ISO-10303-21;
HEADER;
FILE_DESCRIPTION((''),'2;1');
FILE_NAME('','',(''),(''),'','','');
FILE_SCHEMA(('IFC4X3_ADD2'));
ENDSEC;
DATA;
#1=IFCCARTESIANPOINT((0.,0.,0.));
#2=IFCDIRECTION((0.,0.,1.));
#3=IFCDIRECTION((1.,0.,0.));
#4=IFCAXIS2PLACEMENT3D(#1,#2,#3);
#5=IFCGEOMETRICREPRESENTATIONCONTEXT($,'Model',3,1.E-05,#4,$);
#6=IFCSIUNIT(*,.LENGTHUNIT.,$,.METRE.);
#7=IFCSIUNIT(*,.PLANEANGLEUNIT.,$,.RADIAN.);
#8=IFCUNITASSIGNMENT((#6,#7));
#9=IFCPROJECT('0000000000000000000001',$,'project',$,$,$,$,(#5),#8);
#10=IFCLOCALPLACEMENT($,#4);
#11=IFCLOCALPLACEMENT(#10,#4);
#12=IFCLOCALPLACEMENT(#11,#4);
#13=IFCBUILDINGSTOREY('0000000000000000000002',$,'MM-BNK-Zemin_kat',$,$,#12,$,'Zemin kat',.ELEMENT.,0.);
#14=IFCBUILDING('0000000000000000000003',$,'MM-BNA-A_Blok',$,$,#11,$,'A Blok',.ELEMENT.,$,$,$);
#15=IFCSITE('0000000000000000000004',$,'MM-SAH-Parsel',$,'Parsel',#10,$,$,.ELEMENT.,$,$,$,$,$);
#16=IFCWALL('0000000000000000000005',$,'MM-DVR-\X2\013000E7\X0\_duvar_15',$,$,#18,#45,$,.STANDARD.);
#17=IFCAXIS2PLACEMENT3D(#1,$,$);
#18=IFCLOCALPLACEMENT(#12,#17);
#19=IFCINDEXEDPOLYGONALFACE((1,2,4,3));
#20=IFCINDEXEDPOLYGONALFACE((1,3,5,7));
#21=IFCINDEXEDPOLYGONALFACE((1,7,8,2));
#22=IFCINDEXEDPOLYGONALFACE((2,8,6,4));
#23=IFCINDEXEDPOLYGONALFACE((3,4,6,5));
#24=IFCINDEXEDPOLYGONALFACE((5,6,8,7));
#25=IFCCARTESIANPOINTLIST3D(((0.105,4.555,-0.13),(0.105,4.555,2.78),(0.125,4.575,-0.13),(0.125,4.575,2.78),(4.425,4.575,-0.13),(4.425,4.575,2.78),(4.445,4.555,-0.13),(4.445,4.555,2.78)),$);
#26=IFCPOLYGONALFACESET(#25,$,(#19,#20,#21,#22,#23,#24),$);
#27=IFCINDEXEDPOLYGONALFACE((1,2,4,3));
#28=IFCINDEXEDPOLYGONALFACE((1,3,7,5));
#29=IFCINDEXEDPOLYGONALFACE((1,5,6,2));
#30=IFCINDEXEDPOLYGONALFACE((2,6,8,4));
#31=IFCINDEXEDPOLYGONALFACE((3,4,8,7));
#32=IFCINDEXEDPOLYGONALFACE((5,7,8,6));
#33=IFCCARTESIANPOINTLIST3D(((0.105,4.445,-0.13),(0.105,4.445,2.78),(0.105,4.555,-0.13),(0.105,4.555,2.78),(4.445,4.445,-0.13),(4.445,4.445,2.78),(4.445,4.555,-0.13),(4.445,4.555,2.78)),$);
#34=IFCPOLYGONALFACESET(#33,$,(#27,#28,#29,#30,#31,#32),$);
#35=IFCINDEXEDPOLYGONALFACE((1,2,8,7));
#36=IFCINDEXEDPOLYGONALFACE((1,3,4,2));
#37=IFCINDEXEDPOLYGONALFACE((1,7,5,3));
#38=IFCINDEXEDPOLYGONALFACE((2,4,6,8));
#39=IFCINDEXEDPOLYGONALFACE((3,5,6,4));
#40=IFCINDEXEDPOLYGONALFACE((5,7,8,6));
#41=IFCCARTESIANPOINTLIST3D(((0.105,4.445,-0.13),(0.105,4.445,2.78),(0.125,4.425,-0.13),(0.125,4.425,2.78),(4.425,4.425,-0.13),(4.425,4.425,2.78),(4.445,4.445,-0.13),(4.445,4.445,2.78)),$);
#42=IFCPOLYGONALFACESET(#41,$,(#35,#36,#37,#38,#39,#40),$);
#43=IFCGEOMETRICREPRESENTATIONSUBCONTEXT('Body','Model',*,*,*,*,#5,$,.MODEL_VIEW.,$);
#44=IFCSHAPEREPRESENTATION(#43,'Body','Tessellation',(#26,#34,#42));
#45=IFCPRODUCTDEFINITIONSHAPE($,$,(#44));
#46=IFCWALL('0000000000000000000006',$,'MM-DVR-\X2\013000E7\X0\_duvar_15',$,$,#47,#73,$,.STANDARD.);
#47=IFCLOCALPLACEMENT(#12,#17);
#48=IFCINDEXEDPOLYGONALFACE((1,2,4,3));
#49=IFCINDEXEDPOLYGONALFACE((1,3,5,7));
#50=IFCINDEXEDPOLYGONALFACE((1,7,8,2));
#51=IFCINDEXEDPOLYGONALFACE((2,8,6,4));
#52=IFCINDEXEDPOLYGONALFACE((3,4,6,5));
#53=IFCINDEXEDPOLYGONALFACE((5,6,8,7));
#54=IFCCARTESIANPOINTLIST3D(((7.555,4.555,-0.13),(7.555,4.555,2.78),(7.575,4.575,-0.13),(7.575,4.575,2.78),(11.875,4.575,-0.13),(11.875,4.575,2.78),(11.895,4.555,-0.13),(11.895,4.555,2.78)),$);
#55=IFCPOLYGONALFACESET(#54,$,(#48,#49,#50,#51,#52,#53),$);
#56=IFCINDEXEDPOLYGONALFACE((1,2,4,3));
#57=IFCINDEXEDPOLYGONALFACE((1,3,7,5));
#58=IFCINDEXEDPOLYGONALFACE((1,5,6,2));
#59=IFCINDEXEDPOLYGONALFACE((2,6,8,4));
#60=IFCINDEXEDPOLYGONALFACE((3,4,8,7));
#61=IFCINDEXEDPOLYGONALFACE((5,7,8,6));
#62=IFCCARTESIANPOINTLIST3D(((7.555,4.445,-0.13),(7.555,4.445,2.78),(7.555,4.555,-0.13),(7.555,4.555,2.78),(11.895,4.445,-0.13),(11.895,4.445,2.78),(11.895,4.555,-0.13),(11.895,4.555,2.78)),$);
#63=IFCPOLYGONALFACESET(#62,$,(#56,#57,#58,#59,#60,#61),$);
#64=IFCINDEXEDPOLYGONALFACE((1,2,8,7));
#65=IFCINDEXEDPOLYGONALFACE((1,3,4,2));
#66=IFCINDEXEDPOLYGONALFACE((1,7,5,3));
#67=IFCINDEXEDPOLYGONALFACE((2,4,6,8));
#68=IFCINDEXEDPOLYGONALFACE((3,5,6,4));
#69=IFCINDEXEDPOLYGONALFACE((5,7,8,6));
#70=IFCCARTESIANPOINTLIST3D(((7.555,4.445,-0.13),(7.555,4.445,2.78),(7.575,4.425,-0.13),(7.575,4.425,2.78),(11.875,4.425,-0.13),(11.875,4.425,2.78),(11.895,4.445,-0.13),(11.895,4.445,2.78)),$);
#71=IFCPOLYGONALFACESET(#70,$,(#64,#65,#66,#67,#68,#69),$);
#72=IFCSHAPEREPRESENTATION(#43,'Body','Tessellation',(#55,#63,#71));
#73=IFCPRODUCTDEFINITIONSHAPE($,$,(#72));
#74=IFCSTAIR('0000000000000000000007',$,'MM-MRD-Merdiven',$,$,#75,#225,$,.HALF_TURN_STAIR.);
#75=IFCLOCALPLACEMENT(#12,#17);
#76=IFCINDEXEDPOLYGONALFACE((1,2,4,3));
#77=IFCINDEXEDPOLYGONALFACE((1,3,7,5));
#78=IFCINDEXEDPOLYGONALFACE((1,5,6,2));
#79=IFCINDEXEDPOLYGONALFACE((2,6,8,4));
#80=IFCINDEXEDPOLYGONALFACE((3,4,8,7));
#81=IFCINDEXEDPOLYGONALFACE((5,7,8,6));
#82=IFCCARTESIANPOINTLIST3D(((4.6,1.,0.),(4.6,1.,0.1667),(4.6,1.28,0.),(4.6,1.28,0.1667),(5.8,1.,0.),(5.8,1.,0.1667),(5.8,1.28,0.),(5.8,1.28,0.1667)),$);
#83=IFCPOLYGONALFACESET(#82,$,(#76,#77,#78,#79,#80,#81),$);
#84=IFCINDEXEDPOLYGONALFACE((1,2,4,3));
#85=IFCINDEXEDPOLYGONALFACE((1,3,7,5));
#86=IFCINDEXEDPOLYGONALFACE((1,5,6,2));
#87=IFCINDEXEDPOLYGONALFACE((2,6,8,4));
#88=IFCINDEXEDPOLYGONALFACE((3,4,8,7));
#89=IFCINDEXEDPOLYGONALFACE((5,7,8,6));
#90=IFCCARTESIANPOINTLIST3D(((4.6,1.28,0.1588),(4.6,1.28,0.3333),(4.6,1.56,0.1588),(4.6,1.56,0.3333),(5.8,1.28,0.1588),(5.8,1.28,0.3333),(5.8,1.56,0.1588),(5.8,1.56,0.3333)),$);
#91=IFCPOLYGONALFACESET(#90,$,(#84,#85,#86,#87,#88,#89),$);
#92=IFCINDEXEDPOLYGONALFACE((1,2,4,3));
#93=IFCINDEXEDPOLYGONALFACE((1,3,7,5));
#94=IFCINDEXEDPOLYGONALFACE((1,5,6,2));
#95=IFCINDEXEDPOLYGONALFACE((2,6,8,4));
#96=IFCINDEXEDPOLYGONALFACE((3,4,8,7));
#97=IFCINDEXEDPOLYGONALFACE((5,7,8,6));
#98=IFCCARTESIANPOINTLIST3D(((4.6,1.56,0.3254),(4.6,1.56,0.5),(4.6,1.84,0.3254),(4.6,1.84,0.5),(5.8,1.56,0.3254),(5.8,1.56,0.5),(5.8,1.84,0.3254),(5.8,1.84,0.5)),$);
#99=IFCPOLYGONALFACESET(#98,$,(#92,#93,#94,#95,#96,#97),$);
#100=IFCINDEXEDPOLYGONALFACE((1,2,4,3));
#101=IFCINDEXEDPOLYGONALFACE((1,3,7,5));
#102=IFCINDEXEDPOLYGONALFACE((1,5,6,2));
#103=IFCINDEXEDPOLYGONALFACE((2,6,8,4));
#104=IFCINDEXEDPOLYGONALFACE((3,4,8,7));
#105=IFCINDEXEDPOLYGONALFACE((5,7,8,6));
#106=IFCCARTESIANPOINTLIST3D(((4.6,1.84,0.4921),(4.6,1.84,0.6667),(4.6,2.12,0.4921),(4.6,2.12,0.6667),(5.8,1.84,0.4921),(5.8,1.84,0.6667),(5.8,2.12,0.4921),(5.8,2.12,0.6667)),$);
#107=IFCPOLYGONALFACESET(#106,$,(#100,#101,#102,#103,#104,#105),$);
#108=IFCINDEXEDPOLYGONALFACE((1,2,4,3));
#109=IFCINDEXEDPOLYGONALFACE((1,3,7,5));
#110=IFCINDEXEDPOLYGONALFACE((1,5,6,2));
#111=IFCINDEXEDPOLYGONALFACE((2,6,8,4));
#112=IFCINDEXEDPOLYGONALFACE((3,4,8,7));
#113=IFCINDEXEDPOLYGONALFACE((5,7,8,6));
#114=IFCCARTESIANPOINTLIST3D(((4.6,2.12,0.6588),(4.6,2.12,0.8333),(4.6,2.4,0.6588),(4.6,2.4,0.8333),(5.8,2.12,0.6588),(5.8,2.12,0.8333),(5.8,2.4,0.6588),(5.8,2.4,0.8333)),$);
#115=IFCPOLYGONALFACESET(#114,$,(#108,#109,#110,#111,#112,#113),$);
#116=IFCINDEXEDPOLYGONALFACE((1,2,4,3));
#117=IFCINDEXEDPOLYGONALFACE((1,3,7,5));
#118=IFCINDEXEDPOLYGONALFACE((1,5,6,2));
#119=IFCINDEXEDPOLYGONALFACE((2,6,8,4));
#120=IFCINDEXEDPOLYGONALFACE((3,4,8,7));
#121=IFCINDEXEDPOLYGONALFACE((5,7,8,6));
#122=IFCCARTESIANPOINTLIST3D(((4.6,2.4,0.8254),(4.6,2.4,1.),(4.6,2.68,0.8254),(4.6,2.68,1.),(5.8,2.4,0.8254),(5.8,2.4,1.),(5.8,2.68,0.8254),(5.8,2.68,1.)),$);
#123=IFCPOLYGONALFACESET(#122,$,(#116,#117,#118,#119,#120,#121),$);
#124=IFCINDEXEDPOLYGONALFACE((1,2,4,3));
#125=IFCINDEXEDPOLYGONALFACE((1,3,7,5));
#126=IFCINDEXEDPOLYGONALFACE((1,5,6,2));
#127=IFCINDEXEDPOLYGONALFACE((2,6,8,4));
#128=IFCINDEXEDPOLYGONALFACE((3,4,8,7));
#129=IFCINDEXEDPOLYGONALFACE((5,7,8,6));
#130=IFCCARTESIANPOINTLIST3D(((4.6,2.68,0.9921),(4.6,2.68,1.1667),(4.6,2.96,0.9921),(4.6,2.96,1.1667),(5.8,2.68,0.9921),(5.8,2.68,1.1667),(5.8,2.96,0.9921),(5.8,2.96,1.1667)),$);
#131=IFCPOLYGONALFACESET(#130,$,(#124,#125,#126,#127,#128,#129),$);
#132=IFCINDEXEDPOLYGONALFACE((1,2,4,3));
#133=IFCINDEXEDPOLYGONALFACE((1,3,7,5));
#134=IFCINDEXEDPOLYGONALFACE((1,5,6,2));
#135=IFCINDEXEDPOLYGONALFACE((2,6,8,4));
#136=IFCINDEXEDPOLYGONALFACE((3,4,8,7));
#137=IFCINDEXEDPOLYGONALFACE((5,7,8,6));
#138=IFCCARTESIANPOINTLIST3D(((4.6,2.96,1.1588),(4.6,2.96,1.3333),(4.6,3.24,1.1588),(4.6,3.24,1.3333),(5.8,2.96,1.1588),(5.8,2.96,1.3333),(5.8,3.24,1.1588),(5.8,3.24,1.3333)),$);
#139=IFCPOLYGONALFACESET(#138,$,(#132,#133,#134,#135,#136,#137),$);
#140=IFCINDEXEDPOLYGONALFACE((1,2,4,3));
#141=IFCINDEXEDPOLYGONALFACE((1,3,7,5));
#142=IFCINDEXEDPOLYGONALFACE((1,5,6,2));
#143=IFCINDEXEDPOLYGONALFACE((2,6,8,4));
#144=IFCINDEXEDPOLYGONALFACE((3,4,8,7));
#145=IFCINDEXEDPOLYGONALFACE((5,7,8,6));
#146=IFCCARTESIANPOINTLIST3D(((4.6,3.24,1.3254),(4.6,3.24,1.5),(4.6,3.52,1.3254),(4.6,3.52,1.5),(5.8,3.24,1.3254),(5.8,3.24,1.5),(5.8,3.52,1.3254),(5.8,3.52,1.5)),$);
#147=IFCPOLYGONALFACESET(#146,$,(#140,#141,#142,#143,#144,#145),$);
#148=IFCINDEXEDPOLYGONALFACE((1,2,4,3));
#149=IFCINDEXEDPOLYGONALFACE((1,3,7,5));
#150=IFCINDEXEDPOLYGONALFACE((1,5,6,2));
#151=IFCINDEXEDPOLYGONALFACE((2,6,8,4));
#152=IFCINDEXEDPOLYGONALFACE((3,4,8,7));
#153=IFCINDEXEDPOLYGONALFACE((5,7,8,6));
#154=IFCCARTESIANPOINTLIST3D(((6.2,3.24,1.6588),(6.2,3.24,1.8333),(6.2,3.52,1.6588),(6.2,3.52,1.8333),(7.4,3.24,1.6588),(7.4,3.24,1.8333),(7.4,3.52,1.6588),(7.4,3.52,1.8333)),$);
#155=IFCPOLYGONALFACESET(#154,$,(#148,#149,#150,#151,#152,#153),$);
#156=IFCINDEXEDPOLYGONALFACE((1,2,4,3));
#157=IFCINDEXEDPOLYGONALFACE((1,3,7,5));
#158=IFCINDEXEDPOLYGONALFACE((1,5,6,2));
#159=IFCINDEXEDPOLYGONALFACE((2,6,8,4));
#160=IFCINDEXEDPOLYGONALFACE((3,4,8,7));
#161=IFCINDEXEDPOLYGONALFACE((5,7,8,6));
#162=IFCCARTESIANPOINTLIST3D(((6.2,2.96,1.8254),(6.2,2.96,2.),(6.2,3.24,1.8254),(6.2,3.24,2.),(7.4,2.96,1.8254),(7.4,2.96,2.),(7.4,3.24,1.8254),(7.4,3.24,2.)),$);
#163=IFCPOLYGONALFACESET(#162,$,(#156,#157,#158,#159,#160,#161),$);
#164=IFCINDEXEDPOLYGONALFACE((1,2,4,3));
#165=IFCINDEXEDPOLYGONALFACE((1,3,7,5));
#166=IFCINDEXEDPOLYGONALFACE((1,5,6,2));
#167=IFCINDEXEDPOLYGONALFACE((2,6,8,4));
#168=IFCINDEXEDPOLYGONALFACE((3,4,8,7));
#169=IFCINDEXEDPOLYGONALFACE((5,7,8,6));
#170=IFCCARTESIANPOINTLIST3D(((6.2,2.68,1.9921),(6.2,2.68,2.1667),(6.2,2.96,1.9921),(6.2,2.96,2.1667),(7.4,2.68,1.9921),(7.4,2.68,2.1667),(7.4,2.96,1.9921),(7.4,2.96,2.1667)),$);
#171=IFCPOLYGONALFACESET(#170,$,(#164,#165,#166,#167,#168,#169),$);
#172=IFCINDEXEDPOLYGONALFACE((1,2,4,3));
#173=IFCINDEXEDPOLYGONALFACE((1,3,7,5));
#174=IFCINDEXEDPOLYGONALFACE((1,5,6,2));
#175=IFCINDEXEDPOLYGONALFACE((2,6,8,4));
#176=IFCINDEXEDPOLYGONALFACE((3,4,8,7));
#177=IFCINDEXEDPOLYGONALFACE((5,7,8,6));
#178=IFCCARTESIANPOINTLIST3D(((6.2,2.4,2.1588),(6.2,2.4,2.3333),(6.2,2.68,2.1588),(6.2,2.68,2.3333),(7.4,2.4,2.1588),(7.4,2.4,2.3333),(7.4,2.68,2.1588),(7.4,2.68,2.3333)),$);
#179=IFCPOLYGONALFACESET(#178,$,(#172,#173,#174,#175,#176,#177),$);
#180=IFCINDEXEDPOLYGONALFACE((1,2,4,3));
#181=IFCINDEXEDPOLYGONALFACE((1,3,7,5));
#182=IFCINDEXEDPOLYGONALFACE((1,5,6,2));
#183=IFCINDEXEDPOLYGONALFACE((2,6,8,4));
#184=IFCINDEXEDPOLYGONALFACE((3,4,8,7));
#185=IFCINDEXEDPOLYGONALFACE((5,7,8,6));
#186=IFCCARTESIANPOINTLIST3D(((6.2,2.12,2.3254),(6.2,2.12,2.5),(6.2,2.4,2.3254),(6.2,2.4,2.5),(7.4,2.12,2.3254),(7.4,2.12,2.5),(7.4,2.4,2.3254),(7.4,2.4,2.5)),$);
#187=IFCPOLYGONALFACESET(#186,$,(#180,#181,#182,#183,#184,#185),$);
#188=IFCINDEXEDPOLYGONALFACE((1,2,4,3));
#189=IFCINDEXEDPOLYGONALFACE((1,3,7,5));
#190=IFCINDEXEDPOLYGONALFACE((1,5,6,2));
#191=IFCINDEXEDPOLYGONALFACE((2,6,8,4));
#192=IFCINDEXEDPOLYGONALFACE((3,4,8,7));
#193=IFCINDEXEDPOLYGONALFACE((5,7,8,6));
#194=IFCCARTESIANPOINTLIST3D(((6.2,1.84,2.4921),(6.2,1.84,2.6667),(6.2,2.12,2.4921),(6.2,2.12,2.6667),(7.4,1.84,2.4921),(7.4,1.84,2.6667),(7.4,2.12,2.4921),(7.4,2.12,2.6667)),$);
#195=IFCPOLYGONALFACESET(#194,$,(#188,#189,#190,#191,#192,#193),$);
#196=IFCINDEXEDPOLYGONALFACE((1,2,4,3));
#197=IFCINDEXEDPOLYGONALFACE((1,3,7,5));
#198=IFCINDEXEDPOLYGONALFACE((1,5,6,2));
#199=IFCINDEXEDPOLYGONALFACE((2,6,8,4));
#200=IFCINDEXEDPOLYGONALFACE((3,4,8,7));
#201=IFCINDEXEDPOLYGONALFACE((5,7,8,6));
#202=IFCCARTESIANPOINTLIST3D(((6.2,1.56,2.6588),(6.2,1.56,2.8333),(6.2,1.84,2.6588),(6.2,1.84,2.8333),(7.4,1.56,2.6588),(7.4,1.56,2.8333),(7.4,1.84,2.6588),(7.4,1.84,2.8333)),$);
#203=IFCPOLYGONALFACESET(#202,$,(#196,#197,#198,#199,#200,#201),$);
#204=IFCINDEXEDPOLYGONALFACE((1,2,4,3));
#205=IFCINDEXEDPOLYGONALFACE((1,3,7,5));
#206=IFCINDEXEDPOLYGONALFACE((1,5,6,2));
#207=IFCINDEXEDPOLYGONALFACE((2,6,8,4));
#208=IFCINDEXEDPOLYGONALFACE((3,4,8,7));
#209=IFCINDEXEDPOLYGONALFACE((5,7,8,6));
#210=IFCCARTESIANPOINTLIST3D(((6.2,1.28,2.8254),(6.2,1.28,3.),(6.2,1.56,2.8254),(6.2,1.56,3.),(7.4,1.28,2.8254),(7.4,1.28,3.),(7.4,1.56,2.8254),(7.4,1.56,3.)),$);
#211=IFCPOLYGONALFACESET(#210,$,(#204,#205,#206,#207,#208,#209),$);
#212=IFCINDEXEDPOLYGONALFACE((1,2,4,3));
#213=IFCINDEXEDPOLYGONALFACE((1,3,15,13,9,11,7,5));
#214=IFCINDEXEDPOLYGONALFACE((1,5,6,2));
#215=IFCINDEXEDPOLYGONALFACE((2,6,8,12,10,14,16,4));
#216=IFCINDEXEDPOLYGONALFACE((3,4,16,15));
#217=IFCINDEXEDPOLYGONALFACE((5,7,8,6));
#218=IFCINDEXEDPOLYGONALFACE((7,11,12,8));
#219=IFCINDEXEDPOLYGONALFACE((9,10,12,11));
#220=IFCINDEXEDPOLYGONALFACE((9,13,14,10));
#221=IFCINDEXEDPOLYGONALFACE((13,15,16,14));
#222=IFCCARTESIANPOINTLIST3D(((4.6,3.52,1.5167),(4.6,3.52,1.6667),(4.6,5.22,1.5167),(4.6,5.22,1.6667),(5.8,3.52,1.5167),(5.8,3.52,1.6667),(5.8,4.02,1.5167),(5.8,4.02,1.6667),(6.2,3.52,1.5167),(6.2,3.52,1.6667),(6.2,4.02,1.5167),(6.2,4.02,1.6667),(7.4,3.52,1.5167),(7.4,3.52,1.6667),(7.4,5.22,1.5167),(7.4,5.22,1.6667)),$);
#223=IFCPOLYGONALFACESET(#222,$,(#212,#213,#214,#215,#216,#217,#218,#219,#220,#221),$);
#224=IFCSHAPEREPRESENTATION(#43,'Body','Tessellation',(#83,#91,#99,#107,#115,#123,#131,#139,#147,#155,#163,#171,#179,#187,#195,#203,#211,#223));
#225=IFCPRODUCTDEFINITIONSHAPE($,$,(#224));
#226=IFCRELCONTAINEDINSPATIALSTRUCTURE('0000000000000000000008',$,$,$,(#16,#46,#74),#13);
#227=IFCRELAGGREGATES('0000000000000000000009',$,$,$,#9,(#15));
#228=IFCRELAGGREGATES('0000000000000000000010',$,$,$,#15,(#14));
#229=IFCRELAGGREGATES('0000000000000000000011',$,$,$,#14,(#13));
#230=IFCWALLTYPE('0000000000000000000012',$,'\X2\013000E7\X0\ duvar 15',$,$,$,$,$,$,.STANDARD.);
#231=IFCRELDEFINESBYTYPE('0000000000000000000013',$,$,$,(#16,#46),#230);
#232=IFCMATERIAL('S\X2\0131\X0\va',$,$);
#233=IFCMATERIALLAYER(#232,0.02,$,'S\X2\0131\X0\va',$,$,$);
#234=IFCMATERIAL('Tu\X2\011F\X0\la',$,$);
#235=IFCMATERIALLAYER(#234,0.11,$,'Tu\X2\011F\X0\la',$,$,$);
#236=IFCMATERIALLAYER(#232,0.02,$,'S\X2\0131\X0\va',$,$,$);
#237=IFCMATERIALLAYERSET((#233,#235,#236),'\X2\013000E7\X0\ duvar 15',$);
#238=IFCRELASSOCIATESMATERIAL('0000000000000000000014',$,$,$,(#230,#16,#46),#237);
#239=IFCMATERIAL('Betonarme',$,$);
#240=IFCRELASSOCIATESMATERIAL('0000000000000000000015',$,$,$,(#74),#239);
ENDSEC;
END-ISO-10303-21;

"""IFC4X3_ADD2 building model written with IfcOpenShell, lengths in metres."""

from ifc_helpers import new_model, si_unit, frame, origin, origin_with_axes, place, context, subcontext, project, spatial, polyline, outline, extrude, material, layer, layer_set, type_object, element, save


model = new_model("IFC4X3_ADD2")

# Units and contexts
model_context = context("Model", 3, precision=1e-05, world=origin_with_axes())
body_context = subcontext(model_context, "Body", "Model", "MODEL_VIEW")
ifc_project = project(units=[si_unit("LENGTHUNIT", "METRE"), si_unit("PLANEANGLEUNIT", "RADIAN")], contexts=[model_context])

# Site, building, storey
site_placement = place(None, origin_with_axes())
site = spatial("IfcSite", under=ifc_project, at=site_placement, Name="MM-SAH-Parsel", ObjectType="Parsel", CompositionType="ELEMENT")
building_placement = place(site_placement, origin_with_axes())
building = spatial("IfcBuilding", under=site, at=building_placement, Name="MM-BNA-A_Blok", LongName="A Blok", CompositionType="ELEMENT")
storey_placement = place(building_placement, origin_with_axes())
storey = spatial("IfcBuildingStorey", under=building, at=storey_placement, Name="MM-BNK-Zemin_kat", LongName="Zemin kat", CompositionType="ELEMENT", Elevation=0.0)

# Shared definitions
ifc_material_1 = material(Name="Betonarme")

# Shared definitions
ifc_material_2 = material(Name="Tuğla")

# Shared definitions
ifc_material_3 = material(Name="Sıva")
ifc_layer_1 = layer(ifc_material_3, 0.02, Name="Sıva")
ifc_layer_2 = layer(ifc_material_2, 0.11, Name="Tuğla")
ifc_layer_3 = layer(ifc_material_3, 0.02, Name="Sıva")
ifc_layer_set_1 = layer_set([ifc_layer_1, ifc_layer_2, ifc_layer_3], Name="İç duvar 15")
wall_type_1 = type_object("IfcWallType", Name="İç duvar 15", PredefinedType="STANDARD", material=ifc_layer_set_1)

# Walls
wall_1_placement = place(storey_placement, origin_with_axes())
element("IfcWall", 1, at=wall_1_placement, inside=storey, type_object=wall_type_1, material=ifc_layer_set_1, Name="MM-DVR-İç_duvar_15", PredefinedType="STANDARD", context=body_context, shape_type="SweptSolid", body=[
    extrude(outline(polyline([(0.125, 4.575), (4.425, 4.575), (4.445, 4.555), (0.105, 4.555), (0.125, 4.575)])), frame((0.0, 0.0, -0.13)), (0.0, 0.0, 1.0), 2.91),
    extrude(outline(polyline([(0.105, 4.555), (4.445, 4.555), (4.445, 4.445), (0.105, 4.445), (0.105, 4.555)])), frame((0.0, 0.0, -0.13)), (0.0, 0.0, 1.0), 2.91),
    extrude(outline(polyline([(0.105, 4.445), (4.445, 4.445), (4.425, 4.425), (0.125, 4.425), (0.105, 4.445)])), frame((0.0, 0.0, -0.13)), (0.0, 0.0, 1.0), 2.91),
])
wall_2_placement = place(storey_placement, origin_with_axes())
element("IfcWall", 2, at=wall_2_placement, inside=storey, type_object=wall_type_1, material=ifc_layer_set_1, Name="MM-DVR-İç_duvar_15", PredefinedType="STANDARD", context=body_context, shape_type="SweptSolid", body=[
    extrude(outline(polyline([(7.575, 4.575), (11.875, 4.575), (11.895, 4.555), (7.555, 4.555), (7.575, 4.575)])), frame((0.0, 0.0, -0.13)), (0.0, 0.0, 1.0), 2.91),
    extrude(outline(polyline([(7.555, 4.555), (11.895, 4.555), (11.895, 4.445), (7.555, 4.445), (7.555, 4.555)])), frame((0.0, 0.0, -0.13)), (0.0, 0.0, 1.0), 2.91),
    extrude(outline(polyline([(7.555, 4.445), (11.895, 4.445), (11.875, 4.425), (7.575, 4.425), (7.555, 4.445)])), frame((0.0, 0.0, -0.13)), (0.0, 0.0, 1.0), 2.91),
])

# Stair
stair_placement = place(storey_placement, origin_with_axes())
element("IfcStair", 3, at=stair_placement, inside=storey, material=ifc_material_1, Name="MM-MRD-Merdiven", PredefinedType="HALF_TURN_STAIR", context=body_context, shape_type="SweptSolid", body=[
    extrude(outline(polyline([(5.8, 1.0), (5.8, 1.28), (4.6, 1.28), (4.6, 1.0), (5.8, 1.0)])), origin(), (0.0, 0.0, 1.0), 0.1667),
    extrude(outline(polyline([(5.8, 1.28), (5.8, 1.56), (4.6, 1.56), (4.6, 1.28), (5.8, 1.28)])), frame((0.0, 0.0, 0.1588)), (0.0, 0.0, 1.0), 0.1746),
    extrude(outline(polyline([(5.8, 1.56), (5.8, 1.84), (4.6, 1.84), (4.6, 1.56), (5.8, 1.56)])), frame((0.0, 0.0, 0.3254)), (0.0, 0.0, 1.0), 0.1746),
    extrude(outline(polyline([(5.8, 1.84), (5.8, 2.12), (4.6, 2.12), (4.6, 1.84), (5.8, 1.84)])), frame((0.0, 0.0, 0.4921)), (0.0, 0.0, 1.0), 0.1746),
    extrude(outline(polyline([(5.8, 2.12), (5.8, 2.4), (4.6, 2.4), (4.6, 2.12), (5.8, 2.12)])), frame((0.0, 0.0, 0.6588)), (0.0, 0.0, 1.0), 0.1746),
    extrude(outline(polyline([(5.8, 2.4), (5.8, 2.68), (4.6, 2.68), (4.6, 2.4), (5.8, 2.4)])), frame((0.0, 0.0, 0.8254)), (0.0, 0.0, 1.0), 0.1746),
    extrude(outline(polyline([(5.8, 2.68), (5.8, 2.96), (4.6, 2.96), (4.6, 2.68), (5.8, 2.68)])), frame((0.0, 0.0, 0.9921)), (0.0, 0.0, 1.0), 0.1746),
    extrude(outline(polyline([(5.8, 2.96), (5.8, 3.24), (4.6, 3.24), (4.6, 2.96), (5.8, 2.96)])), frame((0.0, 0.0, 1.1588)), (0.0, 0.0, 1.0), 0.1746),
    extrude(outline(polyline([(5.8, 3.24), (5.8, 3.52), (4.6, 3.52), (4.6, 3.24), (5.8, 3.24)])), frame((0.0, 0.0, 1.3254)), (0.0, 0.0, 1.0), 0.1746),
    extrude(outline(polyline([(6.2, 3.52), (6.2, 3.24), (7.4, 3.24), (7.4, 3.52), (6.2, 3.52)])), frame((0.0, 0.0, 1.6588)), (0.0, 0.0, 1.0), 0.1746),
    extrude(outline(polyline([(6.2, 3.24), (6.2, 2.96), (7.4, 2.96), (7.4, 3.24), (6.2, 3.24)])), frame((0.0, 0.0, 1.8254)), (0.0, 0.0, 1.0), 0.1746),
    extrude(outline(polyline([(6.2, 2.96), (6.2, 2.68), (7.4, 2.68), (7.4, 2.96), (6.2, 2.96)])), frame((0.0, 0.0, 1.9921)), (0.0, 0.0, 1.0), 0.1746),
    extrude(outline(polyline([(6.2, 2.68), (6.2, 2.4), (7.4, 2.4), (7.4, 2.68), (6.2, 2.68)])), frame((0.0, 0.0, 2.1588)), (0.0, 0.0, 1.0), 0.1746),
    extrude(outline(polyline([(6.2, 2.4), (6.2, 2.12), (7.4, 2.12), (7.4, 2.4), (6.2, 2.4)])), frame((0.0, 0.0, 2.3254)), (0.0, 0.0, 1.0), 0.1746),
    extrude(outline(polyline([(6.2, 2.12), (6.2, 1.84), (7.4, 1.84), (7.4, 2.12), (6.2, 2.12)])), frame((0.0, 0.0, 2.4921)), (0.0, 0.0, 1.0), 0.1746),
    extrude(outline(polyline([(6.2, 1.84), (6.2, 1.56), (7.4, 1.56), (7.4, 1.84), (6.2, 1.84)])), frame((0.0, 0.0, 2.6588)), (0.0, 0.0, 1.0), 0.1746),
    extrude(outline(polyline([(6.2, 1.56), (6.2, 1.28), (7.4, 1.28), (7.4, 1.56), (6.2, 1.56)])), frame((0.0, 0.0, 2.8254)), (0.0, 0.0, 1.0), 0.1746),
    extrude(outline(polyline([(4.6, 3.52), (4.6, 5.22), (7.4, 5.22), (7.4, 3.52), (6.2, 3.52), (6.2, 4.02), (5.8, 4.02), (5.8, 3.52), (4.6, 3.52)])), frame((0.0, 0.0, 1.5167)), (0.0, 0.0, 1.0), 0.15),
])

save(model, "model.ifc")
